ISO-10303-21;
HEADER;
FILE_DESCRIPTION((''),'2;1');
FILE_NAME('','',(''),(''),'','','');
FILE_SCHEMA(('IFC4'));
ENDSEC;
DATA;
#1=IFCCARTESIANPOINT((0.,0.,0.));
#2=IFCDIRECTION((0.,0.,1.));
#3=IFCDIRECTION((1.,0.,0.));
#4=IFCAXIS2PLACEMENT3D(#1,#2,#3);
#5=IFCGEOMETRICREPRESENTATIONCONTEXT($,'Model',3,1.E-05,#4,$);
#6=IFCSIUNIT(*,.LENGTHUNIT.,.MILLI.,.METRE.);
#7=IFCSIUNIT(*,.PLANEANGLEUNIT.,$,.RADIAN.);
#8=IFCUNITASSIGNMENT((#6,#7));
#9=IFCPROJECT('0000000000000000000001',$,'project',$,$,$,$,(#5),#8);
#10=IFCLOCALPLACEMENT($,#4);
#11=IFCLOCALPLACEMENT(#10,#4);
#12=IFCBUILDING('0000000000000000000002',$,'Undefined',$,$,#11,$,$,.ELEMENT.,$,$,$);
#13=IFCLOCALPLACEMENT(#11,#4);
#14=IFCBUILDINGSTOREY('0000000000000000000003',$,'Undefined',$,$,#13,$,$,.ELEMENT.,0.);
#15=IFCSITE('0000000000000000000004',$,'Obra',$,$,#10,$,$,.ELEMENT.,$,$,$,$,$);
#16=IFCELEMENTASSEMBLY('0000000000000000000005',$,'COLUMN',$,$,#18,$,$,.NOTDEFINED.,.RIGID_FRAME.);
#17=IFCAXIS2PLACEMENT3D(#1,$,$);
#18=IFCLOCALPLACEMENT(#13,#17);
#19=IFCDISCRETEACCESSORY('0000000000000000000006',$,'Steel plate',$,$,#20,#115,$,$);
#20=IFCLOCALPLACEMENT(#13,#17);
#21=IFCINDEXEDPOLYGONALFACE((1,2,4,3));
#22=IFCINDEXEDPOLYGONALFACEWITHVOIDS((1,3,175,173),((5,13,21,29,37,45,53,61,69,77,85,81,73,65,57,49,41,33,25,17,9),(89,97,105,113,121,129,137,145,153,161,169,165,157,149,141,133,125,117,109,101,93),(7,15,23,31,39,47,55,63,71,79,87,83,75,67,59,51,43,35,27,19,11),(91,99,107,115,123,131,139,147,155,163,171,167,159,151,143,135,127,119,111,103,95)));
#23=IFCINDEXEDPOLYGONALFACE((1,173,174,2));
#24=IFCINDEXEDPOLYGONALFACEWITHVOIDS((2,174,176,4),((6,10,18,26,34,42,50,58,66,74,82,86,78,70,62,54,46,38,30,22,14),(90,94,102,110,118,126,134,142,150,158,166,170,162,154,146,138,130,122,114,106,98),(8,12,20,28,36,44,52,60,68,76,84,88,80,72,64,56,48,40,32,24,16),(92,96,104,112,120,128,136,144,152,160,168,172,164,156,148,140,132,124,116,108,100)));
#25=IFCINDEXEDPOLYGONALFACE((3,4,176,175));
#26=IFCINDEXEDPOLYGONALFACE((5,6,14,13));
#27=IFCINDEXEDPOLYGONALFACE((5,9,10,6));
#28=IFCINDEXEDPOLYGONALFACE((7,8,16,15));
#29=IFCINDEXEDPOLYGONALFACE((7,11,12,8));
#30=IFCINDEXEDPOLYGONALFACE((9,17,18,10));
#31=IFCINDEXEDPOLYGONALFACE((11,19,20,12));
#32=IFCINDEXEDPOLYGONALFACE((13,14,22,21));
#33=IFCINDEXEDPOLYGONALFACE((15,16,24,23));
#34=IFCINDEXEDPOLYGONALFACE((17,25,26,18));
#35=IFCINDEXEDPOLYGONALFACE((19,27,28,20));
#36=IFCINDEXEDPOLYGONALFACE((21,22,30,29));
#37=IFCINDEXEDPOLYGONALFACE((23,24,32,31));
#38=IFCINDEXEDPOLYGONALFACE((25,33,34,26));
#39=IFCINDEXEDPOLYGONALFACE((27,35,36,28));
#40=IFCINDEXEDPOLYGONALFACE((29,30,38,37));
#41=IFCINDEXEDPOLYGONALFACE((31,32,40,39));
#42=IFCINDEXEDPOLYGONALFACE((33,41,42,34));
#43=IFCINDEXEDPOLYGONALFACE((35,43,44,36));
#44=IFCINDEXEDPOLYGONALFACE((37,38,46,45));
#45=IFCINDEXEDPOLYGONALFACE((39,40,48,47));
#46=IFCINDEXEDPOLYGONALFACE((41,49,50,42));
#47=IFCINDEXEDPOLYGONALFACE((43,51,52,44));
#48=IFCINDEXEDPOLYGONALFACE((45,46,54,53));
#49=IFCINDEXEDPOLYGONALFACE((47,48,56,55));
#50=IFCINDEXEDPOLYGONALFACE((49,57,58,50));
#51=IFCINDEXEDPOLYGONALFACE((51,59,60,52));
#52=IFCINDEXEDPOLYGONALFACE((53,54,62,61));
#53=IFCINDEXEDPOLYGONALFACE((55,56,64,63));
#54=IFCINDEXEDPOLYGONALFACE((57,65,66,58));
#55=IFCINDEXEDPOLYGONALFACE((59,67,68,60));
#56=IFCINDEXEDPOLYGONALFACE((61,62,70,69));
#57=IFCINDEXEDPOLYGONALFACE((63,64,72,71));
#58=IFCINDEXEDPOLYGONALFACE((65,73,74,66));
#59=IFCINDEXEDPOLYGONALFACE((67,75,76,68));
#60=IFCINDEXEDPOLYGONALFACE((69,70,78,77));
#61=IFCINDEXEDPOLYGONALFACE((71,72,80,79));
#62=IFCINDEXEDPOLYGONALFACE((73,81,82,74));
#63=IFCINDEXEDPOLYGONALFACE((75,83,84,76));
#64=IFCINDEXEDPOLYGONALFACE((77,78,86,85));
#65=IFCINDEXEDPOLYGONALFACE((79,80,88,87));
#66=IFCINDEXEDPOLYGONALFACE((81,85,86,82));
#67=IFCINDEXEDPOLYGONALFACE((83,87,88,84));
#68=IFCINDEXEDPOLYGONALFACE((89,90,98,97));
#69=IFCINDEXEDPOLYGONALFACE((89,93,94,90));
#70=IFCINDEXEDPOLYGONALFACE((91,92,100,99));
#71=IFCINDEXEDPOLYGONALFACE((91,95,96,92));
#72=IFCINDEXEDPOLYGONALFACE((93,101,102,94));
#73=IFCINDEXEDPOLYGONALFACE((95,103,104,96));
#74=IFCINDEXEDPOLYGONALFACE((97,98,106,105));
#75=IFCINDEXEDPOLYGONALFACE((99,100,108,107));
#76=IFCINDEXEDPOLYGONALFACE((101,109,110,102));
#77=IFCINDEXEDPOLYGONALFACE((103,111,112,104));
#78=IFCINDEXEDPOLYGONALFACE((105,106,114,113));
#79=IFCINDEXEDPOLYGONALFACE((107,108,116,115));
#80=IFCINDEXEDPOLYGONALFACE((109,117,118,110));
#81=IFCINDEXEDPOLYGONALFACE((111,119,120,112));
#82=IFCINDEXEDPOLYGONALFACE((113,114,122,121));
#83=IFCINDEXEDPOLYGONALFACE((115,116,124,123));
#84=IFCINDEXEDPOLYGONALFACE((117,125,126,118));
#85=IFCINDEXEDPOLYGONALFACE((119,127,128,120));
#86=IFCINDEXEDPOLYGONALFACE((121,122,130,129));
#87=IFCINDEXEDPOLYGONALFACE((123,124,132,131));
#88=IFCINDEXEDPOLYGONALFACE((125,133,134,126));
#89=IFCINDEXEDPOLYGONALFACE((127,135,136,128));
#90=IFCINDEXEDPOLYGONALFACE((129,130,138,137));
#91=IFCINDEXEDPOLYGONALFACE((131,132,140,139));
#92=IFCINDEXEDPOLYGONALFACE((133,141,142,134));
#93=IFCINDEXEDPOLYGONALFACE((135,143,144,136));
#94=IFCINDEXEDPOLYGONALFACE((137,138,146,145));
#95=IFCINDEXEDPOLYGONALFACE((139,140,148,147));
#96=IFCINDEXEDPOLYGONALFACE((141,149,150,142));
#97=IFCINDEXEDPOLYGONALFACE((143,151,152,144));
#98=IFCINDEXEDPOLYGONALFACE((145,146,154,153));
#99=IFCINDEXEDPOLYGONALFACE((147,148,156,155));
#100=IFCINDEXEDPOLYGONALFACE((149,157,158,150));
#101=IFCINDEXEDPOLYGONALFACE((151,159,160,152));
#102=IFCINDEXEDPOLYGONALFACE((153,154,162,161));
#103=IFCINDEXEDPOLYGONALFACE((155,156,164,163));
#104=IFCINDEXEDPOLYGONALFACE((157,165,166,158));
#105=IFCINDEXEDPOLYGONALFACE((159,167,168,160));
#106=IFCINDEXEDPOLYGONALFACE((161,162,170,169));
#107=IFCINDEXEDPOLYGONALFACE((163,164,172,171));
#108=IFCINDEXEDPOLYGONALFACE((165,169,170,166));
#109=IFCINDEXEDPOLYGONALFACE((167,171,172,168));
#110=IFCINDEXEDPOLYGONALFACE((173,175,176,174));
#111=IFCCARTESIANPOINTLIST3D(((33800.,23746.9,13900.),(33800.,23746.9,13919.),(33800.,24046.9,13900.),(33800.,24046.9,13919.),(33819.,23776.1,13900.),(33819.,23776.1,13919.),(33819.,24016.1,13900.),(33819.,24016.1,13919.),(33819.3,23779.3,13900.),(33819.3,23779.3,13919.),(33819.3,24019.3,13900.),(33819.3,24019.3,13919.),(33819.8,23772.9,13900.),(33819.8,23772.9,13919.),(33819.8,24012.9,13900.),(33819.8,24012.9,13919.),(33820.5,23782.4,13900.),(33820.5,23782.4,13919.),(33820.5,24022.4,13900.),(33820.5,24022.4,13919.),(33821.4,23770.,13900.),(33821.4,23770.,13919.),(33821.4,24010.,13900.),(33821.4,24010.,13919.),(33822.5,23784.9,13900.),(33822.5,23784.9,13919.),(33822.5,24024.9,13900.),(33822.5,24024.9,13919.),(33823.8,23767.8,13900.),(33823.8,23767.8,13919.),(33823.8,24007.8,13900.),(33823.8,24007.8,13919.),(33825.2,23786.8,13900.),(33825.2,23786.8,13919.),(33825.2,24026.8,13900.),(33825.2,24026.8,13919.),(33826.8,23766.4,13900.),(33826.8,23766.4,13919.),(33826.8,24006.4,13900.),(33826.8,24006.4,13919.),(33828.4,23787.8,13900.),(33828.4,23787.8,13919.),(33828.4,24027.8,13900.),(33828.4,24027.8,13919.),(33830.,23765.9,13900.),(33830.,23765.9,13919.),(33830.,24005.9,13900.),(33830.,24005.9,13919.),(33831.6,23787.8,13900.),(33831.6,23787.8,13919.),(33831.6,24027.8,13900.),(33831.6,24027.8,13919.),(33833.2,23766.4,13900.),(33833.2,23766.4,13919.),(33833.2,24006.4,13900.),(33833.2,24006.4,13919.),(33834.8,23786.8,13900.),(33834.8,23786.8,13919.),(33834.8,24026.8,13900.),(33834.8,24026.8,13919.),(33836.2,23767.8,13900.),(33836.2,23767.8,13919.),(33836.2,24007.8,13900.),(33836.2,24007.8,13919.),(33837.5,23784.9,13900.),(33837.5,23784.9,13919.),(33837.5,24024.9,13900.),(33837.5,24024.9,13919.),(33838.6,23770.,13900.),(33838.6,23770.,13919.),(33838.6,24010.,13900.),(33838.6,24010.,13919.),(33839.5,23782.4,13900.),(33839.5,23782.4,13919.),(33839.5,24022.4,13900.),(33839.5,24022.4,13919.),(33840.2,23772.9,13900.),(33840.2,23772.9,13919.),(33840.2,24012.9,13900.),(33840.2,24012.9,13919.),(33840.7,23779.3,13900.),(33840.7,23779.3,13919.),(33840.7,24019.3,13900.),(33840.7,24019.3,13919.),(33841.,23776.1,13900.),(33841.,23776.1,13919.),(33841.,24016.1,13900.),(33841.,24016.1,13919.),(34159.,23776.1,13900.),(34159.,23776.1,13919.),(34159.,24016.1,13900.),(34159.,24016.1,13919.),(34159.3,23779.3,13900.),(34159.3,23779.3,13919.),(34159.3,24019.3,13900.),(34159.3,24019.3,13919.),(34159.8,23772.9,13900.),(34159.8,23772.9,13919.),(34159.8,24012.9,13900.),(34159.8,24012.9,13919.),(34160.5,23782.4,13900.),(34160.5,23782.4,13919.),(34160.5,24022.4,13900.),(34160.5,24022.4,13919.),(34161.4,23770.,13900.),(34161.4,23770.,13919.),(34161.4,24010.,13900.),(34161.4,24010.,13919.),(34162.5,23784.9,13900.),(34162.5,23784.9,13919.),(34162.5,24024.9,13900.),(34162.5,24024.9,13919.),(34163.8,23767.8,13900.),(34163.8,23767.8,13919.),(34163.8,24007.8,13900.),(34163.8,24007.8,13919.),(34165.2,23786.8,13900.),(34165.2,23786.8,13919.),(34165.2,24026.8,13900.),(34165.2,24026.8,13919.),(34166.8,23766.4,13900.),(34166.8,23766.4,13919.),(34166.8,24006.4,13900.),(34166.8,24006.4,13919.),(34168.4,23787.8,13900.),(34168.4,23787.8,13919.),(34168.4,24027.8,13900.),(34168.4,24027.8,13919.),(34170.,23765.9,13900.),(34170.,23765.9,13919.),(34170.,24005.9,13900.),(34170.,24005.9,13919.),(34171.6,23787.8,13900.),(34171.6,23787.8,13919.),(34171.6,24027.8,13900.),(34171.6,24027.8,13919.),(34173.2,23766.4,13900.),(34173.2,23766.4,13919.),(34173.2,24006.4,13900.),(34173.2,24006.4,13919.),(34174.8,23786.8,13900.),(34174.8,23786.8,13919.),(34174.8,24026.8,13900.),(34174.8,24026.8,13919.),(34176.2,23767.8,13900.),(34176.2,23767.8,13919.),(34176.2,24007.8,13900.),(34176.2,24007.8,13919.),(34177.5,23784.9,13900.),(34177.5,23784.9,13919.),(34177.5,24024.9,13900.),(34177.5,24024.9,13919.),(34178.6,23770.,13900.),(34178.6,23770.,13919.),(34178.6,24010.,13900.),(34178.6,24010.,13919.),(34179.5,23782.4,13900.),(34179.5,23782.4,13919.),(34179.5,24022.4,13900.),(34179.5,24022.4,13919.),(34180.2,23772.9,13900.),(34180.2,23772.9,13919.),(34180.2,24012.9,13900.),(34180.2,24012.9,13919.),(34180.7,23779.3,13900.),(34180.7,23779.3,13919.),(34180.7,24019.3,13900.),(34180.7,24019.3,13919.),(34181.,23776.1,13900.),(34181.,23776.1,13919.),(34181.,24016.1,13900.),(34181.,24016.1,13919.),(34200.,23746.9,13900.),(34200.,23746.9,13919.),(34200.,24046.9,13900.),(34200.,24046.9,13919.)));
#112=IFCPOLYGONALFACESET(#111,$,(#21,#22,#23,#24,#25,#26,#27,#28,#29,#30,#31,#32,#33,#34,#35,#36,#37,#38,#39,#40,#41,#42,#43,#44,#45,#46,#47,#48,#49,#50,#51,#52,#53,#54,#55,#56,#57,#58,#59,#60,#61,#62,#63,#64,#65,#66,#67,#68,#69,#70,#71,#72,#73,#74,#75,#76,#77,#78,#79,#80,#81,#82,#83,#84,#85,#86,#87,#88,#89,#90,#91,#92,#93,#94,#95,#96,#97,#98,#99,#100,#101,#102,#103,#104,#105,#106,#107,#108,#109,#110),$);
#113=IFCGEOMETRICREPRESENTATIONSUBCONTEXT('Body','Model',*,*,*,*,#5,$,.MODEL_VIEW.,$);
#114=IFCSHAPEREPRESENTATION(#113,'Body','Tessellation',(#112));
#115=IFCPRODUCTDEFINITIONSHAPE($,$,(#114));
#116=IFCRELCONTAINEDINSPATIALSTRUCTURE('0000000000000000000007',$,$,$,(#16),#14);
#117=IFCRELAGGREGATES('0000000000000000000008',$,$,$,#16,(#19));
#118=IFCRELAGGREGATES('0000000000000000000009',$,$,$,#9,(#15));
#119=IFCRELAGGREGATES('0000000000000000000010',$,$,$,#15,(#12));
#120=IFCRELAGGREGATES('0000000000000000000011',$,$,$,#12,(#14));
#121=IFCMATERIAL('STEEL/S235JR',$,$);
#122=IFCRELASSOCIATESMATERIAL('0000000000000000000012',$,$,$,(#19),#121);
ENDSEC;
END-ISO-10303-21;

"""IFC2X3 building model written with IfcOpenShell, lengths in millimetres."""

from ifc_helpers import new_model, si_unit, frame, origin_with_axes, origin_2d_with_axis, place, context, subcontext, project, spatial, polyline, circle, outline, extrude, source, transform, mapped, material, element, aggregate, save


model = new_model("IFC2X3")

# Units and contexts
model_context = context("Model", 3, precision=1e-05, world=origin_with_axes())
body_context = subcontext(model_context, "Body", "Model", "MODEL_VIEW")
ifc_project = project(units=[si_unit("LENGTHUNIT", "METRE", prefix="MILLI"), si_unit("PLANEANGLEUNIT", "RADIAN")], contexts=[model_context])

# Site, building, storey
site_placement = place(None, origin_with_axes())
site = spatial("IfcSite", under=ifc_project, at=site_placement, Name="Obra", CompositionType="ELEMENT")
building_placement = place(site_placement, origin_with_axes())
building = spatial("IfcBuilding", under=site, at=building_placement, Name="Undefined", CompositionType="ELEMENT")
storey_placement = place(building_placement, origin_with_axes())
storey = spatial("IfcBuildingStorey", under=building, at=storey_placement, Name="Undefined", CompositionType="ELEMENT", Elevation=0.0)

# Element assembly
ifc_material_1 = material(Name="STEEL/S235JR")
assembly_1_placement = place(storey_placement, origin_with_axes())
assembly_1 = element("IfcElementAssembly", 1, at=assembly_1_placement, inside=storey, Name="COLUMN", AssemblyPlace="NOTDEFINED", PredefinedType="RIGID_FRAME")

# Discrete accessory, opening
discrete_accessory_1_placement = place(assembly_1_placement, frame((33800.0, 24046.9, 13909.5), z_axis=(0.0, 0.0, 1.0), x_axis=(0.0, -1.0, 0.0)))
discrete_accessory_1 = element("IfcDiscreteAccessory", 2, at=discrete_accessory_1_placement, material=ifc_material_1, Name="Steel plate", context=body_context, shape_type="SweptSolid", body=[
    extrude(outline(polyline([(0.0, 0.0), (300.0, 0.0), (300.0, 400.0), (0.0, 400.0), (0.0, 0.0)])), frame((0.0, 0.0, -9.5), z_axis=(0.0, 0.0, 1.0), x_axis=(1.0, 0.0, 0.0)), (0.0, 0.0, 1.0), 19.0),
])
shared_shape_1 = source(origin_with_axes(), body_context, "Body", "SweptSolid", [
    extrude(circle(Radius=11.0, at=origin_2d_with_axis()), frame((0.0, -0.1, 0.0), z_axis=(0.0, 1.0, 0.0), x_axis=(1.0, 0.0, 0.0)), (0.0, 0.0, 1.0), 19.2),
])
opening_1_placement = place(assembly_1_placement, frame((34000.0, 24016.9, 13919.0), z_axis=(1.0, 0.0, 0.0), x_axis=(0.0, -1.0, 0.0)))
element("IfcOpeningElement", 3, at=opening_1_placement, cuts=discrete_accessory_1, ObjectType="Opening", context=body_context, shape_type="MappedRepresentation", body=[
    mapped(shared_shape_1, transform((0.0, 0.0, -170.0))),
    mapped(shared_shape_1, transform((0.0, 0.0, 170.0))),
    mapped(shared_shape_1, transform((240.0, 0.0, -170.0))),
    mapped(shared_shape_1, transform((240.0, 0.0, 170.0))),
])
aggregate(assembly_1, [discrete_accessory_1])

save(model, "model.ifc")
